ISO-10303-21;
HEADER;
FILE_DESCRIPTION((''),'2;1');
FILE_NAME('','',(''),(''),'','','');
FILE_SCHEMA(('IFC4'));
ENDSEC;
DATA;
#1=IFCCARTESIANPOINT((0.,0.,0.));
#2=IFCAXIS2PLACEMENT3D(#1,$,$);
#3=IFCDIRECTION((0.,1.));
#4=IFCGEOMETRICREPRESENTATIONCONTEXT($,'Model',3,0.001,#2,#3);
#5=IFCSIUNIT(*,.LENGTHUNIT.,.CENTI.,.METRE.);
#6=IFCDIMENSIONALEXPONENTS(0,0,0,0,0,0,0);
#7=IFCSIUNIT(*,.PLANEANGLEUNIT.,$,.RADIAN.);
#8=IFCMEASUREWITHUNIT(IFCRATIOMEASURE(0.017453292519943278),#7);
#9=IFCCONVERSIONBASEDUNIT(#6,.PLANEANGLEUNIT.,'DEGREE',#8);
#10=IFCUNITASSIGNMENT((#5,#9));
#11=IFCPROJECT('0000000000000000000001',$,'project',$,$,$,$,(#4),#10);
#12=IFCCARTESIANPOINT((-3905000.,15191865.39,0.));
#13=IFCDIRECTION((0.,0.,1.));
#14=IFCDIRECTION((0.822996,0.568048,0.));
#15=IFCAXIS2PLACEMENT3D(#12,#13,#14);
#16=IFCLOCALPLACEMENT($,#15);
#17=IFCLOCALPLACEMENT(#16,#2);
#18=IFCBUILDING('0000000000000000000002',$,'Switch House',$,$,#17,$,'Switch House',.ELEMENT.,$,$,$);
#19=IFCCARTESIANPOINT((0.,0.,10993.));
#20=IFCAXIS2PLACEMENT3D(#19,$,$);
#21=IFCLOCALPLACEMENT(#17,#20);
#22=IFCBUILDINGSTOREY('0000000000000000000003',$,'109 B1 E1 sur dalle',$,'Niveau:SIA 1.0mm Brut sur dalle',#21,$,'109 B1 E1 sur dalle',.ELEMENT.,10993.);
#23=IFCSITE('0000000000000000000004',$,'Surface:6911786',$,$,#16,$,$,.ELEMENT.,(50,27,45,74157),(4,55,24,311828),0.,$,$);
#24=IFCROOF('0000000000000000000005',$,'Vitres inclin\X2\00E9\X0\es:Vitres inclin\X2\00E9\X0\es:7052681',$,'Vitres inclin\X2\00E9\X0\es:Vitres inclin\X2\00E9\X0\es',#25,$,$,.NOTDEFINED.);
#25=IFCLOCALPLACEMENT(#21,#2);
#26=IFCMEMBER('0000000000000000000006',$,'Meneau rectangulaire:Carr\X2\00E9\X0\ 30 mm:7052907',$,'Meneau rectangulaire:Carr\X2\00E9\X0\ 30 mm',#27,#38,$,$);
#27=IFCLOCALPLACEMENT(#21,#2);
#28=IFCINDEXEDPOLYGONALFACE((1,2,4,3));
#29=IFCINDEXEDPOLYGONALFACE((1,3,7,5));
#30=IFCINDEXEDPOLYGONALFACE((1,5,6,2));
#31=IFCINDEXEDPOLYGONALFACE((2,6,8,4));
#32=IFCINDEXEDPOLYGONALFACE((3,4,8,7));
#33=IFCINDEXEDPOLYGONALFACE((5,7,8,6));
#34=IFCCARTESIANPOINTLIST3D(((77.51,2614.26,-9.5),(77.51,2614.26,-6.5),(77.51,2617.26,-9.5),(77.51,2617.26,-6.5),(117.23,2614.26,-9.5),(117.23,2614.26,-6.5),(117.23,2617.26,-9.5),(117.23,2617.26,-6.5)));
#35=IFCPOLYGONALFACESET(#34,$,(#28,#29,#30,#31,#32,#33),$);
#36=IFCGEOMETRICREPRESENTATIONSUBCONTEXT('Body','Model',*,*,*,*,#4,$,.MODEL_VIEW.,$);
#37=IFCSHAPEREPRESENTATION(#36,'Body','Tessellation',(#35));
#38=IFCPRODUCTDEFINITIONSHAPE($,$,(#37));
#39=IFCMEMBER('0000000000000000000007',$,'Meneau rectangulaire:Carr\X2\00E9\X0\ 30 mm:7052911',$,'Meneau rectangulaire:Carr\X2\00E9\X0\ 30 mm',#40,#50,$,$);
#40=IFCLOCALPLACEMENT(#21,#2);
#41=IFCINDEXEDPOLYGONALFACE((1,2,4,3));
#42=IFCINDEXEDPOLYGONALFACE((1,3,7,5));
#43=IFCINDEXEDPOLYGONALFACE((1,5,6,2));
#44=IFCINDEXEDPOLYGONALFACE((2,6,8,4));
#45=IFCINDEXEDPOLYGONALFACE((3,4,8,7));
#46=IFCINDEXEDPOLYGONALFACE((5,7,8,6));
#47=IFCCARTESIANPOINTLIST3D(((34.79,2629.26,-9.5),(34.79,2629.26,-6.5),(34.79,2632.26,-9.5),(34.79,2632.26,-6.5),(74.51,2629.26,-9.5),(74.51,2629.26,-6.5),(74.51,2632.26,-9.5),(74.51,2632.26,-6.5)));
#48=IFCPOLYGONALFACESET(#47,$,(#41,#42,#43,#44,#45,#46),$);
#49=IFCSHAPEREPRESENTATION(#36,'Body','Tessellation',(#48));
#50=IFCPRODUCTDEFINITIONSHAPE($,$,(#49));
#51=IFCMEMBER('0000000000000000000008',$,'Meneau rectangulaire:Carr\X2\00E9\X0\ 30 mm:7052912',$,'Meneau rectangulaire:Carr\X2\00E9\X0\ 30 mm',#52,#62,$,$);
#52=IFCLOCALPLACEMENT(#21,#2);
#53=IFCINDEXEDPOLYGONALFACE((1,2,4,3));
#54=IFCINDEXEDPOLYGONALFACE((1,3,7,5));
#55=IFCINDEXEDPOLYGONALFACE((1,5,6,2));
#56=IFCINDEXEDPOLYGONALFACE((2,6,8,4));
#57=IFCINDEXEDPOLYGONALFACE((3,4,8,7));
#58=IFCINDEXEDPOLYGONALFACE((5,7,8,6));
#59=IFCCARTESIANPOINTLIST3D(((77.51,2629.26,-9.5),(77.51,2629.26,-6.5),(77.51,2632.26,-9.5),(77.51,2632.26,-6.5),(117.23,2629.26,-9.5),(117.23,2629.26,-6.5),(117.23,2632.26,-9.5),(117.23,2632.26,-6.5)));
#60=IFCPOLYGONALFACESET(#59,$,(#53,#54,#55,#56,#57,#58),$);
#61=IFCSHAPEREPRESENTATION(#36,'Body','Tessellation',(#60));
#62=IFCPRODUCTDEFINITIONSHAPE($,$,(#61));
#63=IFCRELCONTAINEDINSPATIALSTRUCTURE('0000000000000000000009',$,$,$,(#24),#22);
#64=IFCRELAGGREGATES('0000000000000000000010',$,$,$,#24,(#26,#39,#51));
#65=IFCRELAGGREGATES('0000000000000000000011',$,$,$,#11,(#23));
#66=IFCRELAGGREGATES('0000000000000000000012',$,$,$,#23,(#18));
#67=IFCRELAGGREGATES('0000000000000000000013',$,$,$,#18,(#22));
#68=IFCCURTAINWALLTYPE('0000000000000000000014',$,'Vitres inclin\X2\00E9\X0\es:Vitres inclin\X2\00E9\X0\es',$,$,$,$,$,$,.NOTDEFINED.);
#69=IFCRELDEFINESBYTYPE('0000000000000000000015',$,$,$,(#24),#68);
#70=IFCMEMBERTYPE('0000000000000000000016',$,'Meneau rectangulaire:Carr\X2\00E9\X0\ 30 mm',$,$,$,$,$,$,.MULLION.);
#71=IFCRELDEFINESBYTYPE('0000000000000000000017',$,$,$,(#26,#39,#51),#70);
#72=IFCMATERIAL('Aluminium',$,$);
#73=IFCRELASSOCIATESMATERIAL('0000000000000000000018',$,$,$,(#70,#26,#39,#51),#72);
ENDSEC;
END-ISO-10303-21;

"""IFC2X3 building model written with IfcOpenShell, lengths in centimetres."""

from ifc_helpers import new_model, entity, si_unit, converted_unit, direction, frame, origin, origin_2d_with_axis, place, context, subcontext, project, spatial, rectangle, extrude, source, transform, mapped, material, type_object, type_shapes, element, aggregate, save


model = new_model("IFC2X3")

# Units and contexts
model_context = context("Model", 3, precision=0.001, world=origin(), true_north=direction((0.0, 1.0)))
body_context = subcontext(model_context, "Body", "Model", "MODEL_VIEW")
ifc_project = project(units=[si_unit("LENGTHUNIT", "METRE", prefix="CENTI"), converted_unit("PLANEANGLEUNIT", "DEGREE", entity("IfcRatioMeasure", 0.017453292519943278), si_unit("PLANEANGLEUNIT", "RADIAN"), dimensions=[0, 0, 0, 0, 0, 0, 0])], contexts=[model_context])

# Site, building, storey
site_placement = place(None, frame((-3905000.0, 15191865.39, 0.0), z_axis=(0.0, 0.0, 1.0), x_axis=(0.822996, 0.568048, 0.0)))
site = spatial("IfcSite", under=ifc_project, at=site_placement, Name="Surface:6911786", CompositionType="ELEMENT", RefLatitude=(50, 27, 45, 74157), RefLongitude=(4, 55, 24, 311828), RefElevation=0.0)
building_placement = place(site_placement, origin())
building = spatial("IfcBuilding", under=site, at=building_placement, Name="Switch House", LongName="Switch House", CompositionType="ELEMENT")
storey_placement = place(building_placement, frame((0.0, 0.0, 10993.0)))
storey = spatial("IfcBuildingStorey", under=building, at=storey_placement, Name="109 B1 E1 sur dalle", ObjectType="Niveau:SIA 1.0mm Brut sur dalle", LongName="109 B1 E1 sur dalle", CompositionType="ELEMENT", Elevation=10993.0)

# Roof, members
curtain_wall_type = type_object("IfcCurtainWallType", Name="Vitres inclinées:Vitres inclinées", PredefinedType="NOTDEFINED")
roof_placement = place(storey_placement, frame((0.0, 0.0, -10993.0)))
roof = element("IfcRoof", 1, at=roof_placement, inside=storey, type_object=curtain_wall_type, Name="Vitres inclinées:Vitres inclinées:7052681", ObjectType="Vitres inclinées:Vitres inclinées", ShapeType="NOTDEFINED")
ifc_material = material(Name="Aluminium")
member_type_1 = type_object("IfcMemberType", Name="Meneau rectangulaire:Carré 30 mm", PredefinedType="MULLION", material=ifc_material)
shared_shape_1 = source(origin(), body_context, "Body", "SweptSolid", [
    extrude(rectangle(XDim=3.0, YDim=3.0, at=origin_2d_with_axis()), frame((0.0, 0.0, -39.72), z_axis=(0.0, 0.0, 1.0), x_axis=(0.0, -1.0, 0.0)), (0.0, 0.0, 1.0), 39.72),
])
type_shapes(member_type_1, [shared_shape_1])
member_1_placement = place(roof_placement, frame((77.51, 2615.76, 10985.0), z_axis=(-1.0, 0.0, 0.0), x_axis=(0.0, 1.0, 0.0)))
member_1 = element("IfcMember", 2, at=member_1_placement, type_object=member_type_1, material=ifc_material, Name="Meneau rectangulaire:Carré 30 mm:7052907", ObjectType="Meneau rectangulaire:Carré 30 mm", context=body_context, shape_type="MappedRepresentation", body=[
    mapped(shared_shape_1, transform((0.0, 0.0, 0.0), scale=1.0)),
])
member_2_placement = place(roof_placement, frame((34.79, 2630.76, 10985.0), z_axis=(-1.0, 0.0, 0.0), x_axis=(0.0, 1.0, 0.0)))
member_2 = element("IfcMember", 3, at=member_2_placement, type_object=member_type_1, material=ifc_material, Name="Meneau rectangulaire:Carré 30 mm:7052911", ObjectType="Meneau rectangulaire:Carré 30 mm", context=body_context, shape_type="MappedRepresentation", body=[
    mapped(shared_shape_1, transform((0.0, 0.0, 0.0), scale=1.0)),
])
member_3_placement = place(roof_placement, frame((77.51, 2630.76, 10985.0), z_axis=(-1.0, 0.0, 0.0), x_axis=(0.0, 1.0, 0.0)))
member_3 = element("IfcMember", 4, at=member_3_placement, type_object=member_type_1, material=ifc_material, Name="Meneau rectangulaire:Carré 30 mm:7052912", ObjectType="Meneau rectangulaire:Carré 30 mm", context=body_context, shape_type="MappedRepresentation", body=[
    mapped(shared_shape_1, transform((0.0, 0.0, 0.0), scale=1.0)),
])
aggregate(roof, [member_1, member_2, member_3])

save(model, "model.ifc")
